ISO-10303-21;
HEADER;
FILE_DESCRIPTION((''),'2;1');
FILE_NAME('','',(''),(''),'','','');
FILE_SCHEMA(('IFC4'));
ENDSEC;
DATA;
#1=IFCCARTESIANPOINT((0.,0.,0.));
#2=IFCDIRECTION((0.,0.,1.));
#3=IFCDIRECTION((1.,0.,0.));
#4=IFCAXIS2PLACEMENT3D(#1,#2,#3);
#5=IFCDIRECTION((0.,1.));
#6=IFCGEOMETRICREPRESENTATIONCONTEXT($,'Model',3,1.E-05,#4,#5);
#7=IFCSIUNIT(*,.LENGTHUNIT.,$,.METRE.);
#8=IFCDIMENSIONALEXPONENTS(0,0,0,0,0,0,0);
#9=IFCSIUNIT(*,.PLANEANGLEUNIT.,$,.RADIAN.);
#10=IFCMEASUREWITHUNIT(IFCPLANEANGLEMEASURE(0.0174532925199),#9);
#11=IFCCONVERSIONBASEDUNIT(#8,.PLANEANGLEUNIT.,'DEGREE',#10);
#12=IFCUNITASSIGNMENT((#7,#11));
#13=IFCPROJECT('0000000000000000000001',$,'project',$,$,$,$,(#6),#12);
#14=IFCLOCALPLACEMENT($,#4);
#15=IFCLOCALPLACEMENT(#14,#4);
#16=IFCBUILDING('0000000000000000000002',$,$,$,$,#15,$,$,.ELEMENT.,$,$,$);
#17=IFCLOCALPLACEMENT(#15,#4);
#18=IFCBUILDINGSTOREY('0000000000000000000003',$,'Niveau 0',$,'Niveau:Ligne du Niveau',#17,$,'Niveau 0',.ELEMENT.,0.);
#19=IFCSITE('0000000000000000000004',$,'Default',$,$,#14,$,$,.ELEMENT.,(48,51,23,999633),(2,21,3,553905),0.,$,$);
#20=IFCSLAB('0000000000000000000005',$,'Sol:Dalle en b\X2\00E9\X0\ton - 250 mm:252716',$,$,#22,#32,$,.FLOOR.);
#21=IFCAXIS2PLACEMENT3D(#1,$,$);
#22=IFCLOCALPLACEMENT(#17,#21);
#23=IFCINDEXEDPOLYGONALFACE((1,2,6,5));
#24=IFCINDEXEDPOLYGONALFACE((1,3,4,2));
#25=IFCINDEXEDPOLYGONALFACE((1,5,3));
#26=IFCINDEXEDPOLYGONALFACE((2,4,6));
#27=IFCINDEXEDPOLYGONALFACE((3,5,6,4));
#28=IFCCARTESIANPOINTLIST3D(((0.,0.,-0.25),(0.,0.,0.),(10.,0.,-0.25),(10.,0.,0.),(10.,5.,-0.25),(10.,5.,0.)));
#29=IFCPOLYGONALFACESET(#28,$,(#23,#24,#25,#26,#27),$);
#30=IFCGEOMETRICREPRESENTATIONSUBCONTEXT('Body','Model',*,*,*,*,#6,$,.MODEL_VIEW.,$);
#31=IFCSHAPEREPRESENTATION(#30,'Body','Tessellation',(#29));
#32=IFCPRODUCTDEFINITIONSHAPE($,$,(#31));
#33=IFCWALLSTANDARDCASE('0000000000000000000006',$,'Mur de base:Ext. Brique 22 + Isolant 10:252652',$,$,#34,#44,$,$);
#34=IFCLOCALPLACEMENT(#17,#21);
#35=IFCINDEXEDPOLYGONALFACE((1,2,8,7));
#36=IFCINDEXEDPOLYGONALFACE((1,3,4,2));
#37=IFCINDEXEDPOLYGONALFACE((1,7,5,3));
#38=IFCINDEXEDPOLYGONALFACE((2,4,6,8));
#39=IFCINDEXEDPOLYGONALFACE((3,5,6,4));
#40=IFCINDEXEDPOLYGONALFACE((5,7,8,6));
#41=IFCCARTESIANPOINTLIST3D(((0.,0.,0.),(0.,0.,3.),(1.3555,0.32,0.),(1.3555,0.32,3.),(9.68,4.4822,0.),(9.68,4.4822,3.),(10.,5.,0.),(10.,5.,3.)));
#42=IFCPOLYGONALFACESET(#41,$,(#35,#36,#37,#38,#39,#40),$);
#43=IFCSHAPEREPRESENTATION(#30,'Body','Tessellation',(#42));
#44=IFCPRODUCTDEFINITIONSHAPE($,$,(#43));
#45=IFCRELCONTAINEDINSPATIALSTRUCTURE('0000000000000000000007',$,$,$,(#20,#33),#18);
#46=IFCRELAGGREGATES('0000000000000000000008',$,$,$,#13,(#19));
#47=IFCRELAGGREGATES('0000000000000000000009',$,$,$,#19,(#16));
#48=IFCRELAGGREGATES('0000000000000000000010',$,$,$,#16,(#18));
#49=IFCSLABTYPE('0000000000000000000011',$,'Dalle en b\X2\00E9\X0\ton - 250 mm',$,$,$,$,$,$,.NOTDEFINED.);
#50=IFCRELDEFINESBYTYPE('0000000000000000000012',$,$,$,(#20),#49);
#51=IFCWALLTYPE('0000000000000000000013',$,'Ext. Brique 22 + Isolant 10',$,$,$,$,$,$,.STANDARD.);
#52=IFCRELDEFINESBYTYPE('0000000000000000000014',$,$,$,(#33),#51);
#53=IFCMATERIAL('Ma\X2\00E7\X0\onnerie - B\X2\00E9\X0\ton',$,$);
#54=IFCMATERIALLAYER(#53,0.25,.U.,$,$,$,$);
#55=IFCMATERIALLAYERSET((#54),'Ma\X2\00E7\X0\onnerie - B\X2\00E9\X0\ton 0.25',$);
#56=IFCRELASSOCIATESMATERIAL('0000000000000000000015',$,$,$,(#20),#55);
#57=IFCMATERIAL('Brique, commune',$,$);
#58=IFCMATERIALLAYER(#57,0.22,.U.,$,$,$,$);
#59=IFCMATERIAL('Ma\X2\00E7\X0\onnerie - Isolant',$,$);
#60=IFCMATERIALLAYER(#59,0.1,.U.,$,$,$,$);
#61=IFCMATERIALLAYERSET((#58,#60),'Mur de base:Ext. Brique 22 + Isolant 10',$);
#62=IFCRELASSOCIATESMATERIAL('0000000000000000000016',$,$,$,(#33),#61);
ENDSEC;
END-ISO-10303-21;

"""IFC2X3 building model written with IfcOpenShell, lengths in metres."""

from ifc_helpers import new_model, entity, si_unit, converted_unit, direction, frame, origin_with_axes, place, context, subcontext, project, spatial, polyline, outline, extrude, material, layer, layer_set, layer_usage, type_object, element, save


model = new_model("IFC2X3")

# Units and contexts
model_context = context("Model", 3, precision=1e-05, world=origin_with_axes(), true_north=direction((0.0, 1.0)))
body_context = subcontext(model_context, "Body", "Model", "MODEL_VIEW")
ifc_project = project(units=[si_unit("LENGTHUNIT", "METRE"), converted_unit("PLANEANGLEUNIT", "DEGREE", entity("IfcPlaneAngleMeasure", 0.0174532925199), si_unit("PLANEANGLEUNIT", "RADIAN"), dimensions=[0, 0, 0, 0, 0, 0, 0])], contexts=[model_context])

# Site, building, storey
site_placement = place(None, origin_with_axes())
site = spatial("IfcSite", under=ifc_project, at=site_placement, Name="Default", CompositionType="ELEMENT", RefLatitude=(48, 51, 23, 999633), RefLongitude=(2, 21, 3, 553905), RefElevation=0.0)
building_placement = place(site_placement, origin_with_axes())
building = spatial("IfcBuilding", under=site, at=building_placement, CompositionType="ELEMENT")
storey_placement = place(building_placement, origin_with_axes())
storey = spatial("IfcBuildingStorey", under=building, at=storey_placement, Name="Niveau 0", ObjectType="Niveau:Ligne du Niveau", LongName="Niveau 0", CompositionType="ELEMENT", Elevation=0.0)

# Slab
ifc_material_1 = material(Name="Maçonnerie - Béton")
ifc_layer_1 = layer(ifc_material_1, 0.25, ventilated="UNKNOWN")
ifc_layer_set_1 = layer_set([ifc_layer_1], Name="Maçonnerie - Béton 0.25")
ifc_layer_usage_1 = layer_usage(ifc_layer_set_1, "AXIS3", "NEGATIVE", 0.25)
slab_type = type_object("IfcSlabType", Name="Dalle en béton - 250 mm", PredefinedType="NOTDEFINED")
slab_placement = place(storey_placement, frame((10.0, 0.0, 0.0), z_axis=(0.0, 0.0, 1.0), x_axis=(1.0, 0.0, 0.0)))
element("IfcSlab", 1, at=slab_placement, inside=storey, type_object=slab_type, material=ifc_layer_usage_1, Name="Sol:Dalle en béton - 250 mm:252716", PredefinedType="FLOOR", context=body_context, shape_type="SweptSolid", body=[
    extrude(outline(polyline([(0.0, 0.0), (0.0, 5.0), (-10.0, 0.0), (0.0, 0.0)])), frame((0.0, 0.0, -0.25), z_axis=(0.0, 0.0, 1.0), x_axis=(1.0, 0.0, 0.0)), (0.0, 0.0, 1.0), 0.25),
])

# Wall
ifc_material_2 = material(Name="Brique, commune")
ifc_layer_2 = layer(ifc_material_2, 0.22, ventilated="UNKNOWN")
ifc_material_3 = material(Name="Maçonnerie - Isolant")
ifc_layer_3 = layer(ifc_material_3, 0.1, ventilated="UNKNOWN")
ifc_layer_set_2 = layer_set([ifc_layer_2, ifc_layer_3], Name="Mur de base:Ext. Brique 22 + Isolant 10")
ifc_layer_usage_2 = layer_usage(ifc_layer_set_2, "AXIS2", "POSITIVE", -0.16)
wall_type = type_object("IfcWallType", Name="Ext. Brique 22 + Isolant 10", PredefinedType="STANDARD")
wall_placement = place(storey_placement, frame((0.6778, 0.16, 0.0), z_axis=(0.0, 0.0, 1.0), x_axis=(0.894427, 0.447214, 0.0)))
element("IfcWallStandardCase", 2, at=wall_placement, inside=storey, type_object=wall_type, material=ifc_layer_usage_2, Name="Mur de base:Ext. Brique 22 + Isolant 10:252652", context=body_context, shape_type="SweptSolid", body=[
    extrude(outline(polyline([(0.6778, -0.16), (9.9848, -0.16), (10.5026, 0.16), (-0.6778, 0.16), (0.6778, -0.16)])), origin_with_axes(), (0.0, 0.0, 1.0), 3.0),
])

save(model, "model.ifc")
